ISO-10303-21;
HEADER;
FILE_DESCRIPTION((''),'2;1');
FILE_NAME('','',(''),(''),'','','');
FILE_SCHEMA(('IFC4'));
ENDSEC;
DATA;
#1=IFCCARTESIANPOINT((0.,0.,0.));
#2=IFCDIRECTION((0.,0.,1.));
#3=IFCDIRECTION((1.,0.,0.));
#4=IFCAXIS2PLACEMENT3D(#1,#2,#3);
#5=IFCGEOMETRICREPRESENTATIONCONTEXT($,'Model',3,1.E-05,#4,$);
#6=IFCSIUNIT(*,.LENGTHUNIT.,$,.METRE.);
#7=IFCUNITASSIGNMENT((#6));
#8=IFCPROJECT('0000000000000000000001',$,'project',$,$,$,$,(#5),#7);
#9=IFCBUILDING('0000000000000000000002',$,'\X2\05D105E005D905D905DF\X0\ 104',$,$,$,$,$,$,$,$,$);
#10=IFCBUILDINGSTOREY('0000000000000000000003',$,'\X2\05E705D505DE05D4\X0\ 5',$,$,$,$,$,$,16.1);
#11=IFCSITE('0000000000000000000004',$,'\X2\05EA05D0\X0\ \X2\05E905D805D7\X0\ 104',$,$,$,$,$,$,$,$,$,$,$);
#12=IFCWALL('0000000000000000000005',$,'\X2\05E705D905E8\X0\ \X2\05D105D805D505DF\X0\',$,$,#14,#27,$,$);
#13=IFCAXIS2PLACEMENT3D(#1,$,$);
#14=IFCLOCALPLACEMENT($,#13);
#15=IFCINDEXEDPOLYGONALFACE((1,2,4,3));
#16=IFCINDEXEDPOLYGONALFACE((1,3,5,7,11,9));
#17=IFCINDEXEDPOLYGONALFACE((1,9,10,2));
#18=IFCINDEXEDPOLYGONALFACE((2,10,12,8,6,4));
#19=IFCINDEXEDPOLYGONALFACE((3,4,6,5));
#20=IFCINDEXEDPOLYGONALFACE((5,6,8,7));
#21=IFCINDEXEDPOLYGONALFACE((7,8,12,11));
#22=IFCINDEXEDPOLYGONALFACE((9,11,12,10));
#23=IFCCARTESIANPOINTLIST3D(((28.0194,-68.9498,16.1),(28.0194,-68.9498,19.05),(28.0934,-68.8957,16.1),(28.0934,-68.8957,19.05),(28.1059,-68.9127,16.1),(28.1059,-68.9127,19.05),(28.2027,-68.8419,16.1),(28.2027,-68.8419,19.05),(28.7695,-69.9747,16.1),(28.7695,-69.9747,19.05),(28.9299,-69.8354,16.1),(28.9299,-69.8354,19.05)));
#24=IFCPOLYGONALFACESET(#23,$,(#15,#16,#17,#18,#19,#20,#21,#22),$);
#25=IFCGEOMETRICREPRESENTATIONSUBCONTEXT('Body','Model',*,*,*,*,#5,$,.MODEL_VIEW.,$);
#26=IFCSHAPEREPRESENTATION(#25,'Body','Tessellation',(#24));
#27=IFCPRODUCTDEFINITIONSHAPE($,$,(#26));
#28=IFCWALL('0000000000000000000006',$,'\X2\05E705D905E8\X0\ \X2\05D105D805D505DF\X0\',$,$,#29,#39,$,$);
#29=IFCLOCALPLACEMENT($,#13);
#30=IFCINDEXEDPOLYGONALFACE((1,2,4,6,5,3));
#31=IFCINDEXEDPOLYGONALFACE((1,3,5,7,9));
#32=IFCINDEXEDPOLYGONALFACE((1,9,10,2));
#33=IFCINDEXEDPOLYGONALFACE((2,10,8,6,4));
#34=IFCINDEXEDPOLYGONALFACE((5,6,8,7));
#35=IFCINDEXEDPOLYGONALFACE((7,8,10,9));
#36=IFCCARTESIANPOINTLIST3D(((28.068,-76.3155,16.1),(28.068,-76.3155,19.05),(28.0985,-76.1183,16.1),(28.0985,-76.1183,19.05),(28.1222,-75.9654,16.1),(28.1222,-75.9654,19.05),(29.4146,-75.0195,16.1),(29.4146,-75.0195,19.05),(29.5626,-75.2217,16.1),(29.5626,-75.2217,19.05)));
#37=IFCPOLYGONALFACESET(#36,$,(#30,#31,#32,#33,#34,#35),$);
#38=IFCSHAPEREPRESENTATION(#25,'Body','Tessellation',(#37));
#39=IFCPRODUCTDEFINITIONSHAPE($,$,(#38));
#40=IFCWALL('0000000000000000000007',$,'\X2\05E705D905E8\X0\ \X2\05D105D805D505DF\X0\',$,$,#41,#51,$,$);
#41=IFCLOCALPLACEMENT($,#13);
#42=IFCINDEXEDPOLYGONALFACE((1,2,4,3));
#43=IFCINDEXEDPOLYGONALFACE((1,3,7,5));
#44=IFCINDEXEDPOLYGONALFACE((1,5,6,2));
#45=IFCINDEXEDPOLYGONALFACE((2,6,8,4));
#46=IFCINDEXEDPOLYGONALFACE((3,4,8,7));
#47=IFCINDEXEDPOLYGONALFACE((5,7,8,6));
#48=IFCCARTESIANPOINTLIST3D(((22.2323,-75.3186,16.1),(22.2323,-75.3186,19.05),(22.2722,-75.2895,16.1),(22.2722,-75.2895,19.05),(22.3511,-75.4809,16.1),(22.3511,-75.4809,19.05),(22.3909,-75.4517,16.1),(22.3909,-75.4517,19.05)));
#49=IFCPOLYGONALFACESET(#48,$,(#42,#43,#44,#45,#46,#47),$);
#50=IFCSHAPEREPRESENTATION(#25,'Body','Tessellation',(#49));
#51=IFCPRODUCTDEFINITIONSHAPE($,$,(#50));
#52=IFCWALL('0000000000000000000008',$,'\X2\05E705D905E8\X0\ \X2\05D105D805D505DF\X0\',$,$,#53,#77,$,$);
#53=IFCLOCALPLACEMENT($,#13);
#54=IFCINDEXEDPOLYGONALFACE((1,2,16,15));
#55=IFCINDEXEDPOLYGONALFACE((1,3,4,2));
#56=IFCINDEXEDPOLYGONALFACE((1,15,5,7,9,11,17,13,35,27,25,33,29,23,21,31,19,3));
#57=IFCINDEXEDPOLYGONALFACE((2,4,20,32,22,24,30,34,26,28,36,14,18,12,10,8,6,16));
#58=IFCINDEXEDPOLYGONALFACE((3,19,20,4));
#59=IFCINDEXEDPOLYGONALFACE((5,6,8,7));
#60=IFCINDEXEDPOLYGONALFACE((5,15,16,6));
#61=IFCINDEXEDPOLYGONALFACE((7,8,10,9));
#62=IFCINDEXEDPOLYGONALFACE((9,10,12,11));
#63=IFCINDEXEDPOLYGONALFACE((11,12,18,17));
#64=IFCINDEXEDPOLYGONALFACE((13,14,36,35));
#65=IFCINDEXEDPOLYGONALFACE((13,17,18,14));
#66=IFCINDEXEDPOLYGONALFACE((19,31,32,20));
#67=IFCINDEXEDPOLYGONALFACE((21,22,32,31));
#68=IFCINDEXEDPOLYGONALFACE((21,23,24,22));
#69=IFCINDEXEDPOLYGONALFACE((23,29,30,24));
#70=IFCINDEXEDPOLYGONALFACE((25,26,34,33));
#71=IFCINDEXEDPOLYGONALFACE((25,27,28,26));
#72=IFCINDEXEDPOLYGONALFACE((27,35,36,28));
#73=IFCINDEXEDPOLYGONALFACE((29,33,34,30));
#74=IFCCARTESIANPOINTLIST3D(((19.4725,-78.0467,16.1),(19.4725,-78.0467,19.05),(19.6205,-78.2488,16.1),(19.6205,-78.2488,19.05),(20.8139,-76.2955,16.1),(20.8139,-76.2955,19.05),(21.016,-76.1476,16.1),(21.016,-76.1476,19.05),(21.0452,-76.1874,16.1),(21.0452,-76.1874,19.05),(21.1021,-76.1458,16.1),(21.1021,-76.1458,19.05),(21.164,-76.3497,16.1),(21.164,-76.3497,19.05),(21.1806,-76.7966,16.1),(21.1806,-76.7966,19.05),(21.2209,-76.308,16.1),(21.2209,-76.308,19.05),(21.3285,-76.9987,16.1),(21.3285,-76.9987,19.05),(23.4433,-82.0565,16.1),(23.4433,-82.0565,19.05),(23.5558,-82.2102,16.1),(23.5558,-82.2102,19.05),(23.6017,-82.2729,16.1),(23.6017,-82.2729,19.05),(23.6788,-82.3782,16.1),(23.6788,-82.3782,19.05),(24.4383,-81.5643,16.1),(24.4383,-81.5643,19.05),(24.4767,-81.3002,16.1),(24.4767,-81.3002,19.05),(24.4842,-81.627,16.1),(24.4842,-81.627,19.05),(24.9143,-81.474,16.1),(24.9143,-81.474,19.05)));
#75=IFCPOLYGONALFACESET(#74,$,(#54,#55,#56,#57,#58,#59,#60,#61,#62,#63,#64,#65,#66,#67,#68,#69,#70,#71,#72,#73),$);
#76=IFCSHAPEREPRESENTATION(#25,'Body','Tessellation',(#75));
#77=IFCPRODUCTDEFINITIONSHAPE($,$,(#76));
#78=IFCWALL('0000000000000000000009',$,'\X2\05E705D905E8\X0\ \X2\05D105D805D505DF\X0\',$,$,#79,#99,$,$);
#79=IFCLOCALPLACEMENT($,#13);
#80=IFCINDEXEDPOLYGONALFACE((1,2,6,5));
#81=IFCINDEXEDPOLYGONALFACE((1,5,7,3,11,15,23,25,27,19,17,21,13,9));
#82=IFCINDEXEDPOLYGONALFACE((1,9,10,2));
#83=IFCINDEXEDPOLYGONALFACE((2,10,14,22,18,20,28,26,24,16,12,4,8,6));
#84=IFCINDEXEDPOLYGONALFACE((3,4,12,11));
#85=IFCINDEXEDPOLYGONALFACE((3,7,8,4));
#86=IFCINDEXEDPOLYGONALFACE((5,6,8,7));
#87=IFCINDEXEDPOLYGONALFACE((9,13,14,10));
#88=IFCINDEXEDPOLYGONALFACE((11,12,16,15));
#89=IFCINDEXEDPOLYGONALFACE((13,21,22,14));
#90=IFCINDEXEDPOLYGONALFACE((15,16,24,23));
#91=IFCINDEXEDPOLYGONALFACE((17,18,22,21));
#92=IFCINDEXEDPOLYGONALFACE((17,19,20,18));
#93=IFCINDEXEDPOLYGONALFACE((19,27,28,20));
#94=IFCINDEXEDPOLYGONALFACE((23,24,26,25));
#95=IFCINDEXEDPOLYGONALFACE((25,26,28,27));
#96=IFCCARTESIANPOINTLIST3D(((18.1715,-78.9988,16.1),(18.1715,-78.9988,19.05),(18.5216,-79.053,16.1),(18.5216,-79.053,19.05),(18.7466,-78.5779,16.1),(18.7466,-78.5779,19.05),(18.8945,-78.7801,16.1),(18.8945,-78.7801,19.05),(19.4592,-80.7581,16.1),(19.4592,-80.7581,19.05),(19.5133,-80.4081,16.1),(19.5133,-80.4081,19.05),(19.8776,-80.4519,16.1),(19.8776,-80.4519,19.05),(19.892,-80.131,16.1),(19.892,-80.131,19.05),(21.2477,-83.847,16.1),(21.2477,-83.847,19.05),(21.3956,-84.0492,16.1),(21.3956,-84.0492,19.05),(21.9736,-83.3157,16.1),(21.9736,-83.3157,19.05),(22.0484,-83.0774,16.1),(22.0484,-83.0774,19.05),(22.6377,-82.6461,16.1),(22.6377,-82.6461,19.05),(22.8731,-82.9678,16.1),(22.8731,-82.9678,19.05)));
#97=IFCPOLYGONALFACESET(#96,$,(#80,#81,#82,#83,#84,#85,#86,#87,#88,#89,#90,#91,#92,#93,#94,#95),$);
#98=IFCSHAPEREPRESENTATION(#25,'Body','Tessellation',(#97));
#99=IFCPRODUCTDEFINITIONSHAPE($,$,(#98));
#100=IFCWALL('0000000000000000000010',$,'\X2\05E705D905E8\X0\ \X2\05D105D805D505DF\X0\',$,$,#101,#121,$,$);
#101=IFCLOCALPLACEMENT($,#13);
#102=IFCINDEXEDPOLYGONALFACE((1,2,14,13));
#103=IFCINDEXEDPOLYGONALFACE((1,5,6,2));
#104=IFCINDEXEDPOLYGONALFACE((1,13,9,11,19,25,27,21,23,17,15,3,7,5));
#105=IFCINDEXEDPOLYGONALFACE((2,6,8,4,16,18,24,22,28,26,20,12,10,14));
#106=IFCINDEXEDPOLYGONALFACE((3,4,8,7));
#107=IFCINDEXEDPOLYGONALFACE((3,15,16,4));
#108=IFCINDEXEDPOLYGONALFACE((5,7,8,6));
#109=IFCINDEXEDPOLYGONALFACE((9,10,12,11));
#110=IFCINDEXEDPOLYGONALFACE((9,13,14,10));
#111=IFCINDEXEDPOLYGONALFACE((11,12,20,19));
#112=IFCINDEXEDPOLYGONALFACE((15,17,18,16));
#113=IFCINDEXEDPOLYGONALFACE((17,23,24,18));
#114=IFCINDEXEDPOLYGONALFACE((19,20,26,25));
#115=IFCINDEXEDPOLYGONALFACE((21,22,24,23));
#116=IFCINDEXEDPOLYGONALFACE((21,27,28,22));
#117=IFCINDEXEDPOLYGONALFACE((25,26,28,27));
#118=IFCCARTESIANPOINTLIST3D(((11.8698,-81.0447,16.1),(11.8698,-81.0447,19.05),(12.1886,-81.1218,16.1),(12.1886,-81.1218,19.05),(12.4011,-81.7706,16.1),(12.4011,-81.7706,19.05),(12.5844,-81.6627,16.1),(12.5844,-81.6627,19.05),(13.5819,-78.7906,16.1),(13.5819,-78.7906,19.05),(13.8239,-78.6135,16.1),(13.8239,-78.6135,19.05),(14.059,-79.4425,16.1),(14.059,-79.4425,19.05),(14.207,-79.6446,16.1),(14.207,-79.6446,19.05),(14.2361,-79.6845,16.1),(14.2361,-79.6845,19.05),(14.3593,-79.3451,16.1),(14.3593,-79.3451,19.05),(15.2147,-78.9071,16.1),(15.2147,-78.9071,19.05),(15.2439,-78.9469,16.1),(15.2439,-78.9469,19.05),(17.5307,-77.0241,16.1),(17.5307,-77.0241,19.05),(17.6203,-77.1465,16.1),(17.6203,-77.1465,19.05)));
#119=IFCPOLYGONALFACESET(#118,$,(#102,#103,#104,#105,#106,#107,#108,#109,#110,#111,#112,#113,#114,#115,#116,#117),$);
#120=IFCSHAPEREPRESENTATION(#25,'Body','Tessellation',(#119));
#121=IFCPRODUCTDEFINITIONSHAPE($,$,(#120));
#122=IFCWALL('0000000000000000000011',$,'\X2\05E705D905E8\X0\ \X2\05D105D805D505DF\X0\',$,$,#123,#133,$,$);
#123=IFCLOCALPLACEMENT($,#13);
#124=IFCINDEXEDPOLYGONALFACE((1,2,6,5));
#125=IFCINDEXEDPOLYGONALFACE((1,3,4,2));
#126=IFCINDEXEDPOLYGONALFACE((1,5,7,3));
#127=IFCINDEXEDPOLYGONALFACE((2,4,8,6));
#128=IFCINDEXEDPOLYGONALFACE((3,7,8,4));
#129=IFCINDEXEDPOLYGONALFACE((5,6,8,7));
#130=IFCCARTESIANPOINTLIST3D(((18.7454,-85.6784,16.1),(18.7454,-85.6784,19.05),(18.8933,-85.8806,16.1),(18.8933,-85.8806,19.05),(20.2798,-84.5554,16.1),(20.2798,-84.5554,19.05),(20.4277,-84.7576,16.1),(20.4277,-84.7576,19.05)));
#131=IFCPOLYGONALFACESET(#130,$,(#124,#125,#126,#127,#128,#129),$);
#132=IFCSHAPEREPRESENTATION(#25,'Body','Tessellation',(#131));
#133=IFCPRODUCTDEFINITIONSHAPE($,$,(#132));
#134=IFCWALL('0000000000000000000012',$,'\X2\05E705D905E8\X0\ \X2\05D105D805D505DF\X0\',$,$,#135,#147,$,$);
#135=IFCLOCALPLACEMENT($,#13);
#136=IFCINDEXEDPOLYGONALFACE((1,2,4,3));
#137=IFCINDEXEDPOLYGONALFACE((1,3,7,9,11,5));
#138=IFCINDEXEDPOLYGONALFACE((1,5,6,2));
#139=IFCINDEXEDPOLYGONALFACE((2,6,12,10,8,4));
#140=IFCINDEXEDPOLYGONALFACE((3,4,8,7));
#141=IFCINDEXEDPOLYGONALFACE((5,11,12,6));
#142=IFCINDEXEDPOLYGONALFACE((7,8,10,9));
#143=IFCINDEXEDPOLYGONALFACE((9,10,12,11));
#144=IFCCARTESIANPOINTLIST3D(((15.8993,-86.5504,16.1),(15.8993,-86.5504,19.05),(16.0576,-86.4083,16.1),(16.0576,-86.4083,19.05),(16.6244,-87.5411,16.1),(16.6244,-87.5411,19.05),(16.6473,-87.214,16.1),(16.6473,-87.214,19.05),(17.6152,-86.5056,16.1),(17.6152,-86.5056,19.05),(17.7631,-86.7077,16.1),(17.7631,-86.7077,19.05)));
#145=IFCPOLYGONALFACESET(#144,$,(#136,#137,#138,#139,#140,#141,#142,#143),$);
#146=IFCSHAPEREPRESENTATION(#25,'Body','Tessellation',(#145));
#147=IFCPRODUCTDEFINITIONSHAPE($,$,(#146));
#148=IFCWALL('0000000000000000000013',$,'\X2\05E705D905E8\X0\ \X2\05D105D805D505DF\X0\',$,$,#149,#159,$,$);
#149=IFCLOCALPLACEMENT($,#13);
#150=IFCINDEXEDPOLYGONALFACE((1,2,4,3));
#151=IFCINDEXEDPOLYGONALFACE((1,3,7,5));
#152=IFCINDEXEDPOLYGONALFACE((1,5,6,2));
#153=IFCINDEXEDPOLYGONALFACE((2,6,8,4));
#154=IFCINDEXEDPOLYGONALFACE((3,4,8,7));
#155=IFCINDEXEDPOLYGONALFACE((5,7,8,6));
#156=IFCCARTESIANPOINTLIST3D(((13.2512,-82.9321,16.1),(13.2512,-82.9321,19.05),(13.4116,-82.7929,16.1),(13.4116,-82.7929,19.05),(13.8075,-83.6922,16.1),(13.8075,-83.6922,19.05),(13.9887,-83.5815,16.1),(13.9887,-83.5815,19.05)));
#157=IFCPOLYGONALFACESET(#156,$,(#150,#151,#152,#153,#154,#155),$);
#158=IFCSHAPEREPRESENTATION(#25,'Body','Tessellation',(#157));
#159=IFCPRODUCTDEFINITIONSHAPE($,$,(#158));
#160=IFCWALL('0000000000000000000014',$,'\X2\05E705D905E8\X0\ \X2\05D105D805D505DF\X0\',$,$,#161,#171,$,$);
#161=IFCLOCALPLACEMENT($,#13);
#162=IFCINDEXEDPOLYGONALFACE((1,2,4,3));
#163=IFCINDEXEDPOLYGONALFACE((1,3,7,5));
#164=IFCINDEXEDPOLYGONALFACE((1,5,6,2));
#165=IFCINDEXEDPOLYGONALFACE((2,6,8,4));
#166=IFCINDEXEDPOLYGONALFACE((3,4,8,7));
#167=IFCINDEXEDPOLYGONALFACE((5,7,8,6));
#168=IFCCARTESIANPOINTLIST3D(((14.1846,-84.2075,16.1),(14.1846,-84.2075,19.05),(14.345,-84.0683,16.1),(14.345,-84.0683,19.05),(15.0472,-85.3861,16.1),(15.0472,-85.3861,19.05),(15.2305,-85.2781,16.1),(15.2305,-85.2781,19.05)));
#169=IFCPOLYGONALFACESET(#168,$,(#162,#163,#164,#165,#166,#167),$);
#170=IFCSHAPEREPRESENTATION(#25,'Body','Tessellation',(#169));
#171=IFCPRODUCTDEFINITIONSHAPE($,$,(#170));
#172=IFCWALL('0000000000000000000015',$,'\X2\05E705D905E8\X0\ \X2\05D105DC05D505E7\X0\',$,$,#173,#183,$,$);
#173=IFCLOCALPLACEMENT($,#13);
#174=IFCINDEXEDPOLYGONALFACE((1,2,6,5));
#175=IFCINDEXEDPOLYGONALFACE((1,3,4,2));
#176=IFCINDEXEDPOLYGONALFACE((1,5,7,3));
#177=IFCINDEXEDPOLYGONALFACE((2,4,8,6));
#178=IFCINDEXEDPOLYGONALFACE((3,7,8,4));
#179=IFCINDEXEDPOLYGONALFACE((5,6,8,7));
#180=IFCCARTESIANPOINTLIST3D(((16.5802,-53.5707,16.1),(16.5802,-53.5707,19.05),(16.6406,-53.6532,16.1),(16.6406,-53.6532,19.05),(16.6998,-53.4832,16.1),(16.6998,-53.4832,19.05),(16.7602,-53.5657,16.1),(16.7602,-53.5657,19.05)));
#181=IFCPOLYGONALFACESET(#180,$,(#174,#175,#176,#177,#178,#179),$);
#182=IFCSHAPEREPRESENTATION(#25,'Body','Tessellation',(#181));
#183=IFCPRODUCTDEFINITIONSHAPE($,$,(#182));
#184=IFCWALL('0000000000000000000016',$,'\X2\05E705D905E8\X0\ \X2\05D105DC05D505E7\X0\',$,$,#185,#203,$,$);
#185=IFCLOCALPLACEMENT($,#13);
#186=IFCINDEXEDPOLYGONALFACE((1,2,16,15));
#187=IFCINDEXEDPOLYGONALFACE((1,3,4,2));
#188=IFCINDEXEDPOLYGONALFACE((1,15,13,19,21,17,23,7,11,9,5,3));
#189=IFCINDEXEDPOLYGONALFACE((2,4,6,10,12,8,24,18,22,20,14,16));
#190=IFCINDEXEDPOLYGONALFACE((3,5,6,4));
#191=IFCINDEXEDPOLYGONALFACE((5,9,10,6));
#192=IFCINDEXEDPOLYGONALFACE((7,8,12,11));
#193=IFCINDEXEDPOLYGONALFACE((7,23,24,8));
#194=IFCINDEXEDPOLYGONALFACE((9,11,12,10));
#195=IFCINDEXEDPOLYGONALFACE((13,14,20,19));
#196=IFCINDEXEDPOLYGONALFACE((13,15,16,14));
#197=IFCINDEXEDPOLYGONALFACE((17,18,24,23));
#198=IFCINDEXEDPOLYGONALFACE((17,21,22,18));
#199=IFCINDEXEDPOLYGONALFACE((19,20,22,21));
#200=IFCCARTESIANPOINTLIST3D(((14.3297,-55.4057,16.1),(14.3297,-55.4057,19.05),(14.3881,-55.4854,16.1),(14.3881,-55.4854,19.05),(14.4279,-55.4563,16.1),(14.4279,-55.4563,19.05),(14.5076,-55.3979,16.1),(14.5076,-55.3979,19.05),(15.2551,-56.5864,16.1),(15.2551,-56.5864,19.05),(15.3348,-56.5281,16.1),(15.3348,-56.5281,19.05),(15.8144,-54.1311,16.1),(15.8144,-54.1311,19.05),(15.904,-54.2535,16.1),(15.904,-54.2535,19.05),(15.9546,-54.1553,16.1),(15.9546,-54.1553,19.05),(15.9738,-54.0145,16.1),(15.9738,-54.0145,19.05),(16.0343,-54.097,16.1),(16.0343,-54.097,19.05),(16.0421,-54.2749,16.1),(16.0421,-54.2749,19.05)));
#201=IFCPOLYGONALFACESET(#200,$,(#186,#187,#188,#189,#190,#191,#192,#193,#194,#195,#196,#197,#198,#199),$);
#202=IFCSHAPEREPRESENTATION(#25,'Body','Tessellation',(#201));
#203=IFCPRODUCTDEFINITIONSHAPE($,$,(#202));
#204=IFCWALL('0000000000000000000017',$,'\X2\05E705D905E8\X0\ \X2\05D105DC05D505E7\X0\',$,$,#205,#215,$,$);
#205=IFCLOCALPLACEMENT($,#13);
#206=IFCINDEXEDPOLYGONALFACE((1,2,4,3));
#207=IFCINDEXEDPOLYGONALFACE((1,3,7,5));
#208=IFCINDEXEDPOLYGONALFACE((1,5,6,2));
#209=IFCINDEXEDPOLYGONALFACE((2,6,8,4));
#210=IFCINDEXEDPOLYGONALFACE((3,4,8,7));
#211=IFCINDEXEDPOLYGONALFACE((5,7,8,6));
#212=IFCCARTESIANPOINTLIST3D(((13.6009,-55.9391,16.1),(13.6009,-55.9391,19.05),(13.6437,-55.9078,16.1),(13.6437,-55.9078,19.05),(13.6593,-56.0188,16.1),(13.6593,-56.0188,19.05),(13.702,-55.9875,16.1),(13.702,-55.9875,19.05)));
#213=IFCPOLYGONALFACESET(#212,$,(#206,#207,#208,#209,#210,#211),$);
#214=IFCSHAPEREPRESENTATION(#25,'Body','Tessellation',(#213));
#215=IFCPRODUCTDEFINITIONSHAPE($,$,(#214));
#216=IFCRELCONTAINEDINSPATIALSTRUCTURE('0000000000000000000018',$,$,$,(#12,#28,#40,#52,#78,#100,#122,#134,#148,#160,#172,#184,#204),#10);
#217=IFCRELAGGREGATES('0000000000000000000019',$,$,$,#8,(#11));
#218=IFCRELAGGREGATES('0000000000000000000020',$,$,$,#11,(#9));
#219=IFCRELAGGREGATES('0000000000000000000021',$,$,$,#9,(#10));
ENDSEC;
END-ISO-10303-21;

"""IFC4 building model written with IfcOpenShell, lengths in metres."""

from ifc_helpers import new_model, si_unit, frame, origin_with_axes, context, subcontext, project, spatial, polyline, outline, extrude, element, save


model = new_model("IFC4")

# Units and contexts
model_context = context("Model", 3, precision=1e-05, world=origin_with_axes())
body_context = subcontext(model_context, "Body", "Model", "MODEL_VIEW")
ifc_project = project(units=[si_unit("LENGTHUNIT", "METRE")], contexts=[model_context])

# Site, building, storey
site = spatial("IfcSite", under=ifc_project, Name="תא שטח 104")
building = spatial("IfcBuilding", under=site, Name="בניין 104")
storey = spatial("IfcBuildingStorey", under=building, Name="קומה 5", Elevation=16.1)

# Walls
element("IfcWall", 1, inside=storey, Name="קיר בטון", context=body_context, shape_type="SweptSolid", body=[
    extrude(outline(polyline([(28.0934, -68.8957), (28.0194, -68.9498), (28.7695, -69.9747), (28.9299, -69.8354), (28.2027, -68.8419), (28.1059, -68.9127), (28.0934, -68.8957)])), frame((0.0, 0.0, 16.1)), (0.0, 0.0, 1.0), 2.95),
])
element("IfcWall", 2, inside=storey, Name="קיר בטון", context=body_context, shape_type="SweptSolid", body=[
    extrude(outline(polyline([(29.4146, -75.0195), (28.1222, -75.9654), (28.0985, -76.1183), (28.068, -76.3155), (29.5626, -75.2217), (29.4146, -75.0195)])), frame((0.0, 0.0, 16.1)), (0.0, 0.0, 1.0), 2.95),
])
element("IfcWall", 3, inside=storey, Name="קיר בטון", context=body_context, shape_type="SweptSolid", body=[
    extrude(outline(polyline([(22.3909, -75.4517), (22.2722, -75.2895), (22.2323, -75.3186), (22.3511, -75.4809), (22.3909, -75.4517)])), frame((0.0, 0.0, 16.1)), (0.0, 0.0, 1.0), 2.95),
])
element("IfcWall", 4, inside=storey, Name="קיר בטון", context=body_context, shape_type="SweptSolid", body=[
    extrude(outline(polyline([(20.8139, -76.2955), (21.1806, -76.7966), (19.4725, -78.0467), (19.6205, -78.2488), (21.3285, -76.9987), (24.4767, -81.3002), (23.4433, -82.0565), (23.5558, -82.2102), (24.4383, -81.5643), (24.4842, -81.627), (23.6017, -82.2729), (23.6788, -82.3782), (24.9143, -81.474), (21.164, -76.3497), (21.2209, -76.308), (21.1021, -76.1458), (21.0452, -76.1874), (21.016, -76.1476), (20.8139, -76.2955)])), frame((0.0, 0.0, 16.1)), (0.0, 0.0, 1.0), 2.95),
])
element("IfcWall", 5, inside=storey, Name="קיר בטון", context=body_context, shape_type="SweptSolid", body=[
    extrude(outline(polyline([(19.5133, -80.4081), (18.5216, -79.053), (18.8945, -78.7801), (18.7466, -78.5779), (18.1715, -78.9988), (19.4592, -80.7581), (19.8776, -80.4519), (21.9736, -83.3157), (21.2477, -83.847), (21.3956, -84.0492), (22.8731, -82.9678), (22.6377, -82.6461), (22.0484, -83.0774), (19.892, -80.131), (19.5133, -80.4081)])), frame((0.0, 0.0, 16.1)), (0.0, 0.0, 1.0), 2.95),
])
element("IfcWall", 6, inside=storey, Name="קיר בטון", context=body_context, shape_type="SweptSolid", body=[
    extrude(outline(polyline([(13.5819, -78.7906), (14.059, -79.4425), (11.8698, -81.0447), (12.4011, -81.7706), (12.5844, -81.6627), (12.1886, -81.1218), (14.207, -79.6446), (14.2361, -79.6845), (15.2439, -78.9469), (15.2147, -78.9071), (17.6203, -77.1465), (17.5307, -77.0241), (14.3593, -79.3451), (13.8239, -78.6135), (13.5819, -78.7906)])), frame((0.0, 0.0, 16.1)), (0.0, 0.0, 1.0), 2.95),
])
element("IfcWall", 7, inside=storey, Name="קיר בטון", context=body_context, shape_type="SweptSolid", body=[
    extrude(outline(polyline([(18.8933, -85.8806), (20.4277, -84.7576), (20.2798, -84.5554), (18.7454, -85.6784), (18.8933, -85.8806)])), frame((0.0, 0.0, 16.1)), (0.0, 0.0, 1.0), 2.95),
])
element("IfcWall", 8, inside=storey, Name="קיר בטון", context=body_context, shape_type="SweptSolid", body=[
    extrude(outline(polyline([(15.8993, -86.5504), (16.6244, -87.5411), (17.7631, -86.7077), (17.6152, -86.5056), (16.6473, -87.214), (16.0576, -86.4083), (15.8993, -86.5504)])), frame((0.0, 0.0, 16.1)), (0.0, 0.0, 1.0), 2.95),
])
element("IfcWall", 9, inside=storey, Name="קיר בטון", context=body_context, shape_type="SweptSolid", body=[
    extrude(outline(polyline([(13.2512, -82.9321), (13.8075, -83.6922), (13.9887, -83.5815), (13.4116, -82.7929), (13.2512, -82.9321)])), frame((0.0, 0.0, 16.1)), (0.0, 0.0, 1.0), 2.95),
])
element("IfcWall", 10, inside=storey, Name="קיר בטון", context=body_context, shape_type="SweptSolid", body=[
    extrude(outline(polyline([(14.1846, -84.2075), (15.0472, -85.3861), (15.2305, -85.2781), (14.345, -84.0683), (14.1846, -84.2075)])), frame((0.0, 0.0, 16.1)), (0.0, 0.0, 1.0), 2.95),
])
element("IfcWall", 11, inside=storey, Name="קיר בלוק", context=body_context, shape_type="SweptSolid", body=[
    extrude(outline(polyline([(16.7602, -53.5657), (16.6998, -53.4832), (16.5802, -53.5707), (16.6406, -53.6532), (16.7602, -53.5657)])), frame((0.0, 0.0, 16.1)), (0.0, 0.0, 1.0), 2.95),
])
element("IfcWall", 12, inside=storey, Name="קיר בלוק", context=body_context, shape_type="SweptSolid", body=[
    extrude(outline(polyline([(15.8144, -54.1311), (15.904, -54.2535), (14.3297, -55.4057), (14.3881, -55.4854), (14.4279, -55.4563), (15.2551, -56.5864), (15.3348, -56.5281), (14.5076, -55.3979), (16.0421, -54.2749), (15.9546, -54.1553), (16.0343, -54.097), (15.9738, -54.0145), (15.8144, -54.1311)])), frame((0.0, 0.0, 16.1)), (0.0, 0.0, 1.0), 2.95),
])
element("IfcWall", 13, inside=storey, Name="קיר בלוק", context=body_context, shape_type="SweptSolid", body=[
    extrude(outline(polyline([(13.6437, -55.9078), (13.6009, -55.9391), (13.6593, -56.0188), (13.702, -55.9875), (13.6437, -55.9078)])), frame((0.0, 0.0, 16.1)), (0.0, 0.0, 1.0), 2.95),
])

save(model, "model.ifc")
